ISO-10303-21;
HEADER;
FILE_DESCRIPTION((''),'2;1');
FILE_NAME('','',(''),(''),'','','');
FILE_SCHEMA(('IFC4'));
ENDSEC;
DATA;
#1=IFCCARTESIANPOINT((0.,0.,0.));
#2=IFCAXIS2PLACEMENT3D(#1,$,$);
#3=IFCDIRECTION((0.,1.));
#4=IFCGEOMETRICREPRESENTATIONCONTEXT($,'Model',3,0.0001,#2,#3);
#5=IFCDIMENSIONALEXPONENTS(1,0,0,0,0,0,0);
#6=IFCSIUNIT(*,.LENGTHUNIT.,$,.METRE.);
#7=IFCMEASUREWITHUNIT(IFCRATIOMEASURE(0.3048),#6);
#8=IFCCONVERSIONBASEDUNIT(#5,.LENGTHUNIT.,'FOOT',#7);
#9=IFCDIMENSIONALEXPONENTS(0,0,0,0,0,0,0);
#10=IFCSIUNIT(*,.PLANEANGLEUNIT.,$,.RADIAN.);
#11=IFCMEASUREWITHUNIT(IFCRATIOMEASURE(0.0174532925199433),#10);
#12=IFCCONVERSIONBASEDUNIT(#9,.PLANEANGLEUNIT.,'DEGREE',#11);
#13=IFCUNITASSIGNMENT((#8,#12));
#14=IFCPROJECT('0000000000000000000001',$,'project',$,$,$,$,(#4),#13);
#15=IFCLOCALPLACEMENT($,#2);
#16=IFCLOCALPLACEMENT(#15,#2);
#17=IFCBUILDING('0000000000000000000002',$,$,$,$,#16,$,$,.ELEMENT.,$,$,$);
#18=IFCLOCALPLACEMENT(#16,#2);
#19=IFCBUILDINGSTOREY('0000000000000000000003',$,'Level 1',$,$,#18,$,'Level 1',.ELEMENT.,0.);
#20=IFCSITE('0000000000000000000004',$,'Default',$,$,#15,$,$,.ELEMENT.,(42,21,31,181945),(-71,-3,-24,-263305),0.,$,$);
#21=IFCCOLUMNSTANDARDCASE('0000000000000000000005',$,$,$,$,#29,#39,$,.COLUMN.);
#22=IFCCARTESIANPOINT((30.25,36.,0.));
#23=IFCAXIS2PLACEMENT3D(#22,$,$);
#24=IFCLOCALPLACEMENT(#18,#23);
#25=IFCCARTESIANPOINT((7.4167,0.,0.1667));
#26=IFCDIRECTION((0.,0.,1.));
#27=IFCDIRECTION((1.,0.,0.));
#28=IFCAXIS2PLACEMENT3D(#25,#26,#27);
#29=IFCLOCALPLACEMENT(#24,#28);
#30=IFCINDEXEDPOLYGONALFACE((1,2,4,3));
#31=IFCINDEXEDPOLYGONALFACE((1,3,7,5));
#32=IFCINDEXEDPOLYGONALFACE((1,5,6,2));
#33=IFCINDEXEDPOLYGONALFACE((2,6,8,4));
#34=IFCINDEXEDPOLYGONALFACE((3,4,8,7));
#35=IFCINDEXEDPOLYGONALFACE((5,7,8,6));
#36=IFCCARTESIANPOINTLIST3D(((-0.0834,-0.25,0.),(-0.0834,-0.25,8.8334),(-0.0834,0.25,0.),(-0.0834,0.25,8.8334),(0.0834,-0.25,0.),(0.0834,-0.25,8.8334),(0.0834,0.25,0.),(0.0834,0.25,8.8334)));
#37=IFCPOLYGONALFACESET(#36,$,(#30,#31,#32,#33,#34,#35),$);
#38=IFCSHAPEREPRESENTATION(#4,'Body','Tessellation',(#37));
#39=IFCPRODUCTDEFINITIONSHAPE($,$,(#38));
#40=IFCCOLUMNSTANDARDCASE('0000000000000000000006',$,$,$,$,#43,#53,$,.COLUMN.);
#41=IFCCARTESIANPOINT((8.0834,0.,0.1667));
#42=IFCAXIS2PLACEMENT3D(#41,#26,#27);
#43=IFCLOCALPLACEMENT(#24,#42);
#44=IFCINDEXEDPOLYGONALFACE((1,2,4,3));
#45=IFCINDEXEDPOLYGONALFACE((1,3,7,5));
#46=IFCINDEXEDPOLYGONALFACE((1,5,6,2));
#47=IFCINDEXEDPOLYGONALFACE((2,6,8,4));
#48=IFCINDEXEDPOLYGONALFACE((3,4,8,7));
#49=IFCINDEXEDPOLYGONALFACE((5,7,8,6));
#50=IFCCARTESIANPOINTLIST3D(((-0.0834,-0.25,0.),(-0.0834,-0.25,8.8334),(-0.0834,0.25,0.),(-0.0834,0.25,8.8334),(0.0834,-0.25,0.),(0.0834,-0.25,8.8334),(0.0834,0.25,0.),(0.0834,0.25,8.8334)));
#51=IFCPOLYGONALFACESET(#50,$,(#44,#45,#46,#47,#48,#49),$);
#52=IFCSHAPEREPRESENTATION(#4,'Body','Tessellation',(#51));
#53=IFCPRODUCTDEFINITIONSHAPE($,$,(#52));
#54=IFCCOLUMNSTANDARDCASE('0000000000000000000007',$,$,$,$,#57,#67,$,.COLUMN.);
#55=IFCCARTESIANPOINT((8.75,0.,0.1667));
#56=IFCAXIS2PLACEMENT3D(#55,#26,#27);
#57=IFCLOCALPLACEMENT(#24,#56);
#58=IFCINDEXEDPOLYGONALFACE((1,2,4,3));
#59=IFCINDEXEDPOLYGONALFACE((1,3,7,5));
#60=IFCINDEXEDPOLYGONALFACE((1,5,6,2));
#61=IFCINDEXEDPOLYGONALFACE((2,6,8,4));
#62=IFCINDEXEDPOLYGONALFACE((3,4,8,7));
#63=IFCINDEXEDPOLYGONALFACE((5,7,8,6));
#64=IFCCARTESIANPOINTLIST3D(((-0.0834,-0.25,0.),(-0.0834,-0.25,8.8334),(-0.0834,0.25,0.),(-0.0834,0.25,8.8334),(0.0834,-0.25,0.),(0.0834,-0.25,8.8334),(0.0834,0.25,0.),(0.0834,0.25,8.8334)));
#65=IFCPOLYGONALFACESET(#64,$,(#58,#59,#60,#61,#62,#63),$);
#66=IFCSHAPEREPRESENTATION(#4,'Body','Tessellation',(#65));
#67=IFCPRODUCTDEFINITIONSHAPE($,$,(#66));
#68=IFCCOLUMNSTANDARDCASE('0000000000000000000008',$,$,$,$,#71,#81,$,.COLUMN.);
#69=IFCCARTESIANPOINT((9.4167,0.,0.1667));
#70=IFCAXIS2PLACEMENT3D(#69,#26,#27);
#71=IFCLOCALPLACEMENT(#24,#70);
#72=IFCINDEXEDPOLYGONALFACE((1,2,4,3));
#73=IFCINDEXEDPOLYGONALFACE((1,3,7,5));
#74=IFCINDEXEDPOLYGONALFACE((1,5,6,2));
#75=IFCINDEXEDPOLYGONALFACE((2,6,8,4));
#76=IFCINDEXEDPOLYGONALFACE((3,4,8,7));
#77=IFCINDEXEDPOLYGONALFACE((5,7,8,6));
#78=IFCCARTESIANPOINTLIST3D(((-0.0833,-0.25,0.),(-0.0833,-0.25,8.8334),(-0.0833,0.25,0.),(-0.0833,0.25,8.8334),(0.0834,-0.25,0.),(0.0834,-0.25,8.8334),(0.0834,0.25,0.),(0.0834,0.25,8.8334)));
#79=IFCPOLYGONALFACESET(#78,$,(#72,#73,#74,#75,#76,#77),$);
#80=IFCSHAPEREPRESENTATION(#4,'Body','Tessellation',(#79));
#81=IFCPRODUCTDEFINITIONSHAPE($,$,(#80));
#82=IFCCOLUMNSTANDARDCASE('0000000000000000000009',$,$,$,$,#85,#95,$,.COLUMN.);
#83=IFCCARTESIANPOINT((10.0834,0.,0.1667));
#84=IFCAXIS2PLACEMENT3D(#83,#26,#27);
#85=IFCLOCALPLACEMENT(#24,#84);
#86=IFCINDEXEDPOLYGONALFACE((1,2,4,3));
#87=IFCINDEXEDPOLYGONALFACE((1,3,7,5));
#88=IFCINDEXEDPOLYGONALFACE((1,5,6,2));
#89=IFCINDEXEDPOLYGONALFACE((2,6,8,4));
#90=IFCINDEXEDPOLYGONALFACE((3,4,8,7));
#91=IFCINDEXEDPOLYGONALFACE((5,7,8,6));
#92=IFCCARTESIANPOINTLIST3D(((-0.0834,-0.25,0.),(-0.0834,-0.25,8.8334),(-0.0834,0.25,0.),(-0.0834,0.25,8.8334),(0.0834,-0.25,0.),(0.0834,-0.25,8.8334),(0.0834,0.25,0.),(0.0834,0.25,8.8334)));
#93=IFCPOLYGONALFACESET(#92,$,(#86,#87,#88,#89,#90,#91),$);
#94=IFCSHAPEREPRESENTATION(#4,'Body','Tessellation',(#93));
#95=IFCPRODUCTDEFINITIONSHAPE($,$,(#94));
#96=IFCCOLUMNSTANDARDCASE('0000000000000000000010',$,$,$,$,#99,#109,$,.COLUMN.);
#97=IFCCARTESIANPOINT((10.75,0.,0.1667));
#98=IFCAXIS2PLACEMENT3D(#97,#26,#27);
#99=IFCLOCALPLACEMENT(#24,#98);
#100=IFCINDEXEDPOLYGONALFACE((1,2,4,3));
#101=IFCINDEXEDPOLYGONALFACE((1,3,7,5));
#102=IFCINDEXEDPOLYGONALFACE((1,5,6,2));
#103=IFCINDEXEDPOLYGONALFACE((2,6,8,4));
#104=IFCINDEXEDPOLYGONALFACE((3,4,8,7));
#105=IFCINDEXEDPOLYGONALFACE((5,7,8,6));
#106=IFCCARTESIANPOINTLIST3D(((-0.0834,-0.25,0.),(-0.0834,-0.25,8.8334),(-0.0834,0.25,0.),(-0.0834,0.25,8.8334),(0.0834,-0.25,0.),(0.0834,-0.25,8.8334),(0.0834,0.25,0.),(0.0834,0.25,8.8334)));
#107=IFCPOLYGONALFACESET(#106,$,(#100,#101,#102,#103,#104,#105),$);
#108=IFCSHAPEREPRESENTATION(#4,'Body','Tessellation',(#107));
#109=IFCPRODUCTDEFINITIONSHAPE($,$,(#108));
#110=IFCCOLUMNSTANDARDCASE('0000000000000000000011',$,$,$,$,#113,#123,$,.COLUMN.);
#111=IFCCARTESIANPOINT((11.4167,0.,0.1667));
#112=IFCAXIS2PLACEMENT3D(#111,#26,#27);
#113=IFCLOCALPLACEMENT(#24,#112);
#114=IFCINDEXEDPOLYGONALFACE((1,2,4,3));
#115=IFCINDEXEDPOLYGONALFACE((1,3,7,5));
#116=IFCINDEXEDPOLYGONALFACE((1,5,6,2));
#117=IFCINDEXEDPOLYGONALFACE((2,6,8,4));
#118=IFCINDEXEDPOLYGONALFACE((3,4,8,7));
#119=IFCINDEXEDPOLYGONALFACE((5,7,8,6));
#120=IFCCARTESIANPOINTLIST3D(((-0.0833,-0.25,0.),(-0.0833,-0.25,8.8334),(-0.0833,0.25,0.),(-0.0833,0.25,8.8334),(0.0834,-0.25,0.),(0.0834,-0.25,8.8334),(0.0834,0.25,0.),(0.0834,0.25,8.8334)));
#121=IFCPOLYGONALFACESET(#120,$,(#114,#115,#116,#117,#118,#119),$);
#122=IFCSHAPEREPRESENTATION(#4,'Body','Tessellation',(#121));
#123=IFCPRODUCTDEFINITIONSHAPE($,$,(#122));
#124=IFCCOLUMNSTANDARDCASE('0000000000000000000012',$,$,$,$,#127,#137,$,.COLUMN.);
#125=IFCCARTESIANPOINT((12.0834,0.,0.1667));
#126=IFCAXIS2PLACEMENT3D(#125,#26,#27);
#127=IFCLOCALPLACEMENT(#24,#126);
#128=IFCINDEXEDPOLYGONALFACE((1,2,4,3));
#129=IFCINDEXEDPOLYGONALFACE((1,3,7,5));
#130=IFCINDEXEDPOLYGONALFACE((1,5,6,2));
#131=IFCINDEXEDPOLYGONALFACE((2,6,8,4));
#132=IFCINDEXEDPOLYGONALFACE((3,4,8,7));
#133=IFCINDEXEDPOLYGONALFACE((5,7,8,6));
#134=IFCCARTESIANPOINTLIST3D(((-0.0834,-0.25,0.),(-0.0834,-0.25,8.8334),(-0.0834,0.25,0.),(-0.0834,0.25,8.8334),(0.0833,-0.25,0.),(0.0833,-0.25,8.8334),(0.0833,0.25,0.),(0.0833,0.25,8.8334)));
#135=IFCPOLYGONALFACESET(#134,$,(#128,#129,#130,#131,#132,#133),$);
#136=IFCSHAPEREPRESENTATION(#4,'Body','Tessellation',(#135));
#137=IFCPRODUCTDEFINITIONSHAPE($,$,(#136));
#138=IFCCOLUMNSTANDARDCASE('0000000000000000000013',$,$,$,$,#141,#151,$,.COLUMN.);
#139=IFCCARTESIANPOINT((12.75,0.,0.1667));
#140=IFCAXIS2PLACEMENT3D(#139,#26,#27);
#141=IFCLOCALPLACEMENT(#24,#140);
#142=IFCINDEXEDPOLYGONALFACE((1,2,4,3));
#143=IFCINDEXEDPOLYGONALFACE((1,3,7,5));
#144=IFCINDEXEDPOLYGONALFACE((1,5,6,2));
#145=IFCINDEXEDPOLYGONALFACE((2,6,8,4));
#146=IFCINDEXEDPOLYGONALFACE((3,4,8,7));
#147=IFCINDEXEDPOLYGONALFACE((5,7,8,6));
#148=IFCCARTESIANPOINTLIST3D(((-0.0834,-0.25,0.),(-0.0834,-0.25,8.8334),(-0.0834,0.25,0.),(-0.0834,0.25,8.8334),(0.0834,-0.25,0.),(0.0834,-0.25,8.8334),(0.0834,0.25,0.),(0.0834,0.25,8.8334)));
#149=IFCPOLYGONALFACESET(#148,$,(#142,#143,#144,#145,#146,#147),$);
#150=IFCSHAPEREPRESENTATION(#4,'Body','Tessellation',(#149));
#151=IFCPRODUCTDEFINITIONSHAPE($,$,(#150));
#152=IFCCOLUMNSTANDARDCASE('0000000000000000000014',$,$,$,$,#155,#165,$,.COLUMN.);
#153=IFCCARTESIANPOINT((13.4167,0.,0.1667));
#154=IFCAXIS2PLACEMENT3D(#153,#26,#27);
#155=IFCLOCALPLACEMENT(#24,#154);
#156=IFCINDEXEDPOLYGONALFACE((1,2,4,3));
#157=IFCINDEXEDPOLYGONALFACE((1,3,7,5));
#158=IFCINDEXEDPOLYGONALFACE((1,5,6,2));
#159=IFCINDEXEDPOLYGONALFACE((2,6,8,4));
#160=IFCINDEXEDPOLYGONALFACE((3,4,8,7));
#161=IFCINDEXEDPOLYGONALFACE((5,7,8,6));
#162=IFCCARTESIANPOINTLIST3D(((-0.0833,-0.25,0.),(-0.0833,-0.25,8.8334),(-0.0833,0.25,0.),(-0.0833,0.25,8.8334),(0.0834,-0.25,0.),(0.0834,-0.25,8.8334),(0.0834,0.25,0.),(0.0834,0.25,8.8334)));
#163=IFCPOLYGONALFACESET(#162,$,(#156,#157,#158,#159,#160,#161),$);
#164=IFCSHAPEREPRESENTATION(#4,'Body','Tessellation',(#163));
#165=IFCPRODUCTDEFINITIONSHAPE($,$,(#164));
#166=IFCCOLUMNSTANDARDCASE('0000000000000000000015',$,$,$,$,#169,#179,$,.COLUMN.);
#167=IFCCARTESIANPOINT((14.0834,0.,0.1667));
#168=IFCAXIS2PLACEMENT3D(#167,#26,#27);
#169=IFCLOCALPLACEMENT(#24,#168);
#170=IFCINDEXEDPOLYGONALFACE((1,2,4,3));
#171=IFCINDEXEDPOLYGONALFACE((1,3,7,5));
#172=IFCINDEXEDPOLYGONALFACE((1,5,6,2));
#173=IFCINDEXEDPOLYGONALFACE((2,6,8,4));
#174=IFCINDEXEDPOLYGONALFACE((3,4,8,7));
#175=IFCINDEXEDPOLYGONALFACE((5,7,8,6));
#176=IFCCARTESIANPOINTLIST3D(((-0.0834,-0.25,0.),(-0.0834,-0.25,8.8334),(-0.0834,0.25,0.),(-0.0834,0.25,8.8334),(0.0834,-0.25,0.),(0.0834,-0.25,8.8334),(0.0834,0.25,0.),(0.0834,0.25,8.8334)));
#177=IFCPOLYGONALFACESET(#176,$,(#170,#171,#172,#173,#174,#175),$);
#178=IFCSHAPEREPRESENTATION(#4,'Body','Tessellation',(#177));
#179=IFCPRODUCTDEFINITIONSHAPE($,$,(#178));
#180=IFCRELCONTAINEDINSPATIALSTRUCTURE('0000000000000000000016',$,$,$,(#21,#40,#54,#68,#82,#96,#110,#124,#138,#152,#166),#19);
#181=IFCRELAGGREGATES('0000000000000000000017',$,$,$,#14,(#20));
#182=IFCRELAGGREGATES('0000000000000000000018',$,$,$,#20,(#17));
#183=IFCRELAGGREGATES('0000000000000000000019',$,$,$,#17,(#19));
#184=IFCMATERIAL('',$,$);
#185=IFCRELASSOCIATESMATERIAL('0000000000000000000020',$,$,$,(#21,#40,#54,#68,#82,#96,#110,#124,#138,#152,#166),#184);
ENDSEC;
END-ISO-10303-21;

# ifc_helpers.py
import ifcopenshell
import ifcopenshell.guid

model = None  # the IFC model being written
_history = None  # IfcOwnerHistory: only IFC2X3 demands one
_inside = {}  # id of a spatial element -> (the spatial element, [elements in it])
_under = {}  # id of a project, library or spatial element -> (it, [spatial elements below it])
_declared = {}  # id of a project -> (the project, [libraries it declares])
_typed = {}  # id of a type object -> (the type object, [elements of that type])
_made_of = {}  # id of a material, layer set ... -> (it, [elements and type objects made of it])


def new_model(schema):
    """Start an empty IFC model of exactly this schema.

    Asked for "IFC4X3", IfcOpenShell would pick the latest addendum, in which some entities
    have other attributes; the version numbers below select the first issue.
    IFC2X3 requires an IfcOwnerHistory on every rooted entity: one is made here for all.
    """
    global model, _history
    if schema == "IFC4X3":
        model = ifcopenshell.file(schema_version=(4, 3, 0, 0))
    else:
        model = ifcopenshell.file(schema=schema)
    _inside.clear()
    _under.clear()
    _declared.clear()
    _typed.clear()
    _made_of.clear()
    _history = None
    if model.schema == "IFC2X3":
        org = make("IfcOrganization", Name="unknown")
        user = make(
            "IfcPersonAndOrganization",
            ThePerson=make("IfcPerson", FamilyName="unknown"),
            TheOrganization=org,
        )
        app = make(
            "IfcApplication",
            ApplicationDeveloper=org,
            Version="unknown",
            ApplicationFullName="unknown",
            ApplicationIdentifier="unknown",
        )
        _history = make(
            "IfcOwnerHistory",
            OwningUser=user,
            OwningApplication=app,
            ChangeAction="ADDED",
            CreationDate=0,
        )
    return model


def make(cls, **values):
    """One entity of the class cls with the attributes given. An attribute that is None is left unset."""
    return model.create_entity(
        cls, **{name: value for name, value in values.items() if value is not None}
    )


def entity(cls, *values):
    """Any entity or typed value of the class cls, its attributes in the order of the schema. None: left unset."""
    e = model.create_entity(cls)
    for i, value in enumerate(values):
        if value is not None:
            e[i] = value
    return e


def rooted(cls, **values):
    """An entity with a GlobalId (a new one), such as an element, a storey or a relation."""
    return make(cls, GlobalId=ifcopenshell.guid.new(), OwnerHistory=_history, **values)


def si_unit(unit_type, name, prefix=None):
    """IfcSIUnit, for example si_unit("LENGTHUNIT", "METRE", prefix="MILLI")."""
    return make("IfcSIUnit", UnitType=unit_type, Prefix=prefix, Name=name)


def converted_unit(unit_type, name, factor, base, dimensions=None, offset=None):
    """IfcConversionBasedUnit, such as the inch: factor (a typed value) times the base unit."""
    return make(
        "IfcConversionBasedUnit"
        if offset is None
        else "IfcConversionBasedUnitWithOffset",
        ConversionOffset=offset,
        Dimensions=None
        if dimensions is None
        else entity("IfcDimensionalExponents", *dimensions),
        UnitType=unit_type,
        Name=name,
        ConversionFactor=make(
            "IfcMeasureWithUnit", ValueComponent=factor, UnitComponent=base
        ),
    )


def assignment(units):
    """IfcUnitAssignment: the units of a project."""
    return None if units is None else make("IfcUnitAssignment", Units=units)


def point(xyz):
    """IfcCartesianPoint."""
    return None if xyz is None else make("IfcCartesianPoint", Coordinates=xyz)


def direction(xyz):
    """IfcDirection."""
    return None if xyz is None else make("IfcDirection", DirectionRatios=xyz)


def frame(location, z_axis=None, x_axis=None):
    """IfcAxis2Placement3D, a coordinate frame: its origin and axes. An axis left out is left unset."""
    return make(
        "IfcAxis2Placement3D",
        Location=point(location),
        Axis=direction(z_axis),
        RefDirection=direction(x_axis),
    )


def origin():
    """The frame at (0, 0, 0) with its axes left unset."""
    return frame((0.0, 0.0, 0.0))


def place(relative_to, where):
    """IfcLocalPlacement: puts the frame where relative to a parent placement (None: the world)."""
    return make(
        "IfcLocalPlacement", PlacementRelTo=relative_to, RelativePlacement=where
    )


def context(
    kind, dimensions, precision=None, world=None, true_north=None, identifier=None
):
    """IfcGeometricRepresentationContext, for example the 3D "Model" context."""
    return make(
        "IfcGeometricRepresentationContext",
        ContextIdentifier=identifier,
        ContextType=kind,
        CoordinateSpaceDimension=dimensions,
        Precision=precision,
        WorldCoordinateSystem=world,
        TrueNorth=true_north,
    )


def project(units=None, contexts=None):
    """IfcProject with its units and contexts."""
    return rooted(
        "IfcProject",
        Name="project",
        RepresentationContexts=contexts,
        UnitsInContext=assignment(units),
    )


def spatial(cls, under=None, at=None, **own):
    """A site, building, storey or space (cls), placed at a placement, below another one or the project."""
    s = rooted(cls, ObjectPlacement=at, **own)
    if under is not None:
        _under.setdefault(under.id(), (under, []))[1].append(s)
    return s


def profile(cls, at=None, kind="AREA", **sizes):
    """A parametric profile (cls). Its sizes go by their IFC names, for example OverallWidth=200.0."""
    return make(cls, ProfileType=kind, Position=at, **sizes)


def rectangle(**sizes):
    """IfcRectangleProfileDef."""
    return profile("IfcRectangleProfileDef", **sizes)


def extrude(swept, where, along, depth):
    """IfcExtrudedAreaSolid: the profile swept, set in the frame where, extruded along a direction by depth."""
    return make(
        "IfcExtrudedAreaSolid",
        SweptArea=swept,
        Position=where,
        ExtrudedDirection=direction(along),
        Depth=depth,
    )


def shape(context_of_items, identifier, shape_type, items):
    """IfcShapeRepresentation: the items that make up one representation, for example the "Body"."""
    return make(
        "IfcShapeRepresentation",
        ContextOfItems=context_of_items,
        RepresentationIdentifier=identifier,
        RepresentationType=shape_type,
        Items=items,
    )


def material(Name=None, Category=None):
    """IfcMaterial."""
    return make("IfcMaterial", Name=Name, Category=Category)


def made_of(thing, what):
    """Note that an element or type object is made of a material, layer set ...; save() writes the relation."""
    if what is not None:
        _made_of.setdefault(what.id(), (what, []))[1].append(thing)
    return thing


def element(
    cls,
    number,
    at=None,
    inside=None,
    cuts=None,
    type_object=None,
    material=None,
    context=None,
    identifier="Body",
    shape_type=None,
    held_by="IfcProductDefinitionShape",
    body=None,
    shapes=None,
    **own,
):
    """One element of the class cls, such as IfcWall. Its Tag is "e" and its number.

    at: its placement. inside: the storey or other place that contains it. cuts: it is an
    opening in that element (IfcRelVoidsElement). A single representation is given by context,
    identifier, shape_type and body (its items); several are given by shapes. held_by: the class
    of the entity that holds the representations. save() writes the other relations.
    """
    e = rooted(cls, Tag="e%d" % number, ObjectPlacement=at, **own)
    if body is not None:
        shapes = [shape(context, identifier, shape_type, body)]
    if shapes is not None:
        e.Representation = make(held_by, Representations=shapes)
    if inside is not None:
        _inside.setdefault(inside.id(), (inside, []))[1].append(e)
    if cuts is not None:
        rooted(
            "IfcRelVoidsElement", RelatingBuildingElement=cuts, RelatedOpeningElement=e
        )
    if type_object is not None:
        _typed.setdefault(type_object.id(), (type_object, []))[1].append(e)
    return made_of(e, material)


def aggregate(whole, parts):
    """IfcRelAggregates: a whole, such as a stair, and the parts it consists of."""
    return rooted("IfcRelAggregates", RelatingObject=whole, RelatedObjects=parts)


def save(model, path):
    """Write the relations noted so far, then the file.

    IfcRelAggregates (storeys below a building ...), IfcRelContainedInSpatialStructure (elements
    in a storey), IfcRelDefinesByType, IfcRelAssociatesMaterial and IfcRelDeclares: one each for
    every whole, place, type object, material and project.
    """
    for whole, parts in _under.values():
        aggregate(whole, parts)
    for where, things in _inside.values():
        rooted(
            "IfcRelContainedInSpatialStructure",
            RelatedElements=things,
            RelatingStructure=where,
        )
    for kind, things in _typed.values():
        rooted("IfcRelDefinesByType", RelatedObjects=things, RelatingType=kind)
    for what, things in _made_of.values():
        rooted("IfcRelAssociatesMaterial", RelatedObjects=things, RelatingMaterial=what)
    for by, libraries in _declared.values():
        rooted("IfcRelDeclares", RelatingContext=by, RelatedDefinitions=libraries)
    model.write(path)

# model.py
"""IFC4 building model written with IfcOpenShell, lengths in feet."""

from ifc_helpers import new_model, entity, si_unit, converted_unit, direction, frame, origin, place, context, project, spatial, rectangle, extrude, material, element, save


model = new_model("IFC4")

# Units and contexts
model_context = context("Model", 3, precision=0.0001, world=origin(), true_north=direction((0.0, 1.0)))
ifc_project = project(units=[converted_unit("LENGTHUNIT", "FOOT", entity("IfcRatioMeasure", 0.3048), si_unit("LENGTHUNIT", "METRE"), dimensions=[1, 0, 0, 0, 0, 0, 0]), converted_unit("PLANEANGLEUNIT", "DEGREE", entity("IfcRatioMeasure", 0.0174532925199433), si_unit("PLANEANGLEUNIT", "RADIAN"), dimensions=[0, 0, 0, 0, 0, 0, 0])], contexts=[model_context])

# Site, building, storey
site_placement = place(None, origin())
site = spatial("IfcSite", under=ifc_project, at=site_placement, Name="Default", CompositionType="ELEMENT", RefLatitude=(42, 21, 31, 181945), RefLongitude=(-71, -3, -24, -263305), RefElevation=0.0)
building_placement = place(site_placement, origin())
building = spatial("IfcBuilding", under=site, at=building_placement, CompositionType="ELEMENT")
storey_placement = place(building_placement, origin())
storey = spatial("IfcBuildingStorey", under=building, at=storey_placement, Name="Level 1", LongName="Level 1", CompositionType="ELEMENT", Elevation=0.0)

# Columns
ifc_material_1 = material(Name="")
placement_1 = place(storey_placement, frame((30.25, 36.0, 0.0)))
for number, where, z_axis, x_axis in (
    (1, (7.4167, 0.0, 0.1667), (0.0, 0.0, 1.0), (1.0, 0.0, 0.0)),
    (2, (8.0834, 0.0, 0.1667), (0.0, 0.0, 1.0), (1.0, 0.0, 0.0)),
    (3, (8.75, 0.0, 0.1667), (0.0, 0.0, 1.0), (1.0, 0.0, 0.0)),
    (4, (9.4167, 0.0, 0.1667), (0.0, 0.0, 1.0), (1.0, 0.0, 0.0)),
    (5, (10.0834, 0.0, 0.1667), (0.0, 0.0, 1.0), (1.0, 0.0, 0.0)),
    (6, (10.75, 0.0, 0.1667), (0.0, 0.0, 1.0), (1.0, 0.0, 0.0)),
    (7, (11.4167, 0.0, 0.1667), (0.0, 0.0, 1.0), (1.0, 0.0, 0.0)),
    (8, (12.0834, 0.0, 0.1667), (0.0, 0.0, 1.0), (1.0, 0.0, 0.0)),
    (9, (12.75, 0.0, 0.1667), (0.0, 0.0, 1.0), (1.0, 0.0, 0.0)),
    (10, (13.4167, 0.0, 0.1667), (0.0, 0.0, 1.0), (1.0, 0.0, 0.0)),
    (11, (14.0834, 0.0, 0.1667), (0.0, 0.0, 1.0), (1.0, 0.0, 0.0)),
):
    element("IfcColumnStandardCase", number, at=place(placement_1, frame(where, z_axis=z_axis, x_axis=x_axis)), inside=storey, material=ifc_material_1, PredefinedType="COLUMN", context=model_context, shape_type="SweptSolid", body=[
        extrude(rectangle(XDim=0.1667, YDim=0.5), origin(), (0.0, 0.0, 1.0), 8.8334),
    ])

save(model, "model.ifc")
